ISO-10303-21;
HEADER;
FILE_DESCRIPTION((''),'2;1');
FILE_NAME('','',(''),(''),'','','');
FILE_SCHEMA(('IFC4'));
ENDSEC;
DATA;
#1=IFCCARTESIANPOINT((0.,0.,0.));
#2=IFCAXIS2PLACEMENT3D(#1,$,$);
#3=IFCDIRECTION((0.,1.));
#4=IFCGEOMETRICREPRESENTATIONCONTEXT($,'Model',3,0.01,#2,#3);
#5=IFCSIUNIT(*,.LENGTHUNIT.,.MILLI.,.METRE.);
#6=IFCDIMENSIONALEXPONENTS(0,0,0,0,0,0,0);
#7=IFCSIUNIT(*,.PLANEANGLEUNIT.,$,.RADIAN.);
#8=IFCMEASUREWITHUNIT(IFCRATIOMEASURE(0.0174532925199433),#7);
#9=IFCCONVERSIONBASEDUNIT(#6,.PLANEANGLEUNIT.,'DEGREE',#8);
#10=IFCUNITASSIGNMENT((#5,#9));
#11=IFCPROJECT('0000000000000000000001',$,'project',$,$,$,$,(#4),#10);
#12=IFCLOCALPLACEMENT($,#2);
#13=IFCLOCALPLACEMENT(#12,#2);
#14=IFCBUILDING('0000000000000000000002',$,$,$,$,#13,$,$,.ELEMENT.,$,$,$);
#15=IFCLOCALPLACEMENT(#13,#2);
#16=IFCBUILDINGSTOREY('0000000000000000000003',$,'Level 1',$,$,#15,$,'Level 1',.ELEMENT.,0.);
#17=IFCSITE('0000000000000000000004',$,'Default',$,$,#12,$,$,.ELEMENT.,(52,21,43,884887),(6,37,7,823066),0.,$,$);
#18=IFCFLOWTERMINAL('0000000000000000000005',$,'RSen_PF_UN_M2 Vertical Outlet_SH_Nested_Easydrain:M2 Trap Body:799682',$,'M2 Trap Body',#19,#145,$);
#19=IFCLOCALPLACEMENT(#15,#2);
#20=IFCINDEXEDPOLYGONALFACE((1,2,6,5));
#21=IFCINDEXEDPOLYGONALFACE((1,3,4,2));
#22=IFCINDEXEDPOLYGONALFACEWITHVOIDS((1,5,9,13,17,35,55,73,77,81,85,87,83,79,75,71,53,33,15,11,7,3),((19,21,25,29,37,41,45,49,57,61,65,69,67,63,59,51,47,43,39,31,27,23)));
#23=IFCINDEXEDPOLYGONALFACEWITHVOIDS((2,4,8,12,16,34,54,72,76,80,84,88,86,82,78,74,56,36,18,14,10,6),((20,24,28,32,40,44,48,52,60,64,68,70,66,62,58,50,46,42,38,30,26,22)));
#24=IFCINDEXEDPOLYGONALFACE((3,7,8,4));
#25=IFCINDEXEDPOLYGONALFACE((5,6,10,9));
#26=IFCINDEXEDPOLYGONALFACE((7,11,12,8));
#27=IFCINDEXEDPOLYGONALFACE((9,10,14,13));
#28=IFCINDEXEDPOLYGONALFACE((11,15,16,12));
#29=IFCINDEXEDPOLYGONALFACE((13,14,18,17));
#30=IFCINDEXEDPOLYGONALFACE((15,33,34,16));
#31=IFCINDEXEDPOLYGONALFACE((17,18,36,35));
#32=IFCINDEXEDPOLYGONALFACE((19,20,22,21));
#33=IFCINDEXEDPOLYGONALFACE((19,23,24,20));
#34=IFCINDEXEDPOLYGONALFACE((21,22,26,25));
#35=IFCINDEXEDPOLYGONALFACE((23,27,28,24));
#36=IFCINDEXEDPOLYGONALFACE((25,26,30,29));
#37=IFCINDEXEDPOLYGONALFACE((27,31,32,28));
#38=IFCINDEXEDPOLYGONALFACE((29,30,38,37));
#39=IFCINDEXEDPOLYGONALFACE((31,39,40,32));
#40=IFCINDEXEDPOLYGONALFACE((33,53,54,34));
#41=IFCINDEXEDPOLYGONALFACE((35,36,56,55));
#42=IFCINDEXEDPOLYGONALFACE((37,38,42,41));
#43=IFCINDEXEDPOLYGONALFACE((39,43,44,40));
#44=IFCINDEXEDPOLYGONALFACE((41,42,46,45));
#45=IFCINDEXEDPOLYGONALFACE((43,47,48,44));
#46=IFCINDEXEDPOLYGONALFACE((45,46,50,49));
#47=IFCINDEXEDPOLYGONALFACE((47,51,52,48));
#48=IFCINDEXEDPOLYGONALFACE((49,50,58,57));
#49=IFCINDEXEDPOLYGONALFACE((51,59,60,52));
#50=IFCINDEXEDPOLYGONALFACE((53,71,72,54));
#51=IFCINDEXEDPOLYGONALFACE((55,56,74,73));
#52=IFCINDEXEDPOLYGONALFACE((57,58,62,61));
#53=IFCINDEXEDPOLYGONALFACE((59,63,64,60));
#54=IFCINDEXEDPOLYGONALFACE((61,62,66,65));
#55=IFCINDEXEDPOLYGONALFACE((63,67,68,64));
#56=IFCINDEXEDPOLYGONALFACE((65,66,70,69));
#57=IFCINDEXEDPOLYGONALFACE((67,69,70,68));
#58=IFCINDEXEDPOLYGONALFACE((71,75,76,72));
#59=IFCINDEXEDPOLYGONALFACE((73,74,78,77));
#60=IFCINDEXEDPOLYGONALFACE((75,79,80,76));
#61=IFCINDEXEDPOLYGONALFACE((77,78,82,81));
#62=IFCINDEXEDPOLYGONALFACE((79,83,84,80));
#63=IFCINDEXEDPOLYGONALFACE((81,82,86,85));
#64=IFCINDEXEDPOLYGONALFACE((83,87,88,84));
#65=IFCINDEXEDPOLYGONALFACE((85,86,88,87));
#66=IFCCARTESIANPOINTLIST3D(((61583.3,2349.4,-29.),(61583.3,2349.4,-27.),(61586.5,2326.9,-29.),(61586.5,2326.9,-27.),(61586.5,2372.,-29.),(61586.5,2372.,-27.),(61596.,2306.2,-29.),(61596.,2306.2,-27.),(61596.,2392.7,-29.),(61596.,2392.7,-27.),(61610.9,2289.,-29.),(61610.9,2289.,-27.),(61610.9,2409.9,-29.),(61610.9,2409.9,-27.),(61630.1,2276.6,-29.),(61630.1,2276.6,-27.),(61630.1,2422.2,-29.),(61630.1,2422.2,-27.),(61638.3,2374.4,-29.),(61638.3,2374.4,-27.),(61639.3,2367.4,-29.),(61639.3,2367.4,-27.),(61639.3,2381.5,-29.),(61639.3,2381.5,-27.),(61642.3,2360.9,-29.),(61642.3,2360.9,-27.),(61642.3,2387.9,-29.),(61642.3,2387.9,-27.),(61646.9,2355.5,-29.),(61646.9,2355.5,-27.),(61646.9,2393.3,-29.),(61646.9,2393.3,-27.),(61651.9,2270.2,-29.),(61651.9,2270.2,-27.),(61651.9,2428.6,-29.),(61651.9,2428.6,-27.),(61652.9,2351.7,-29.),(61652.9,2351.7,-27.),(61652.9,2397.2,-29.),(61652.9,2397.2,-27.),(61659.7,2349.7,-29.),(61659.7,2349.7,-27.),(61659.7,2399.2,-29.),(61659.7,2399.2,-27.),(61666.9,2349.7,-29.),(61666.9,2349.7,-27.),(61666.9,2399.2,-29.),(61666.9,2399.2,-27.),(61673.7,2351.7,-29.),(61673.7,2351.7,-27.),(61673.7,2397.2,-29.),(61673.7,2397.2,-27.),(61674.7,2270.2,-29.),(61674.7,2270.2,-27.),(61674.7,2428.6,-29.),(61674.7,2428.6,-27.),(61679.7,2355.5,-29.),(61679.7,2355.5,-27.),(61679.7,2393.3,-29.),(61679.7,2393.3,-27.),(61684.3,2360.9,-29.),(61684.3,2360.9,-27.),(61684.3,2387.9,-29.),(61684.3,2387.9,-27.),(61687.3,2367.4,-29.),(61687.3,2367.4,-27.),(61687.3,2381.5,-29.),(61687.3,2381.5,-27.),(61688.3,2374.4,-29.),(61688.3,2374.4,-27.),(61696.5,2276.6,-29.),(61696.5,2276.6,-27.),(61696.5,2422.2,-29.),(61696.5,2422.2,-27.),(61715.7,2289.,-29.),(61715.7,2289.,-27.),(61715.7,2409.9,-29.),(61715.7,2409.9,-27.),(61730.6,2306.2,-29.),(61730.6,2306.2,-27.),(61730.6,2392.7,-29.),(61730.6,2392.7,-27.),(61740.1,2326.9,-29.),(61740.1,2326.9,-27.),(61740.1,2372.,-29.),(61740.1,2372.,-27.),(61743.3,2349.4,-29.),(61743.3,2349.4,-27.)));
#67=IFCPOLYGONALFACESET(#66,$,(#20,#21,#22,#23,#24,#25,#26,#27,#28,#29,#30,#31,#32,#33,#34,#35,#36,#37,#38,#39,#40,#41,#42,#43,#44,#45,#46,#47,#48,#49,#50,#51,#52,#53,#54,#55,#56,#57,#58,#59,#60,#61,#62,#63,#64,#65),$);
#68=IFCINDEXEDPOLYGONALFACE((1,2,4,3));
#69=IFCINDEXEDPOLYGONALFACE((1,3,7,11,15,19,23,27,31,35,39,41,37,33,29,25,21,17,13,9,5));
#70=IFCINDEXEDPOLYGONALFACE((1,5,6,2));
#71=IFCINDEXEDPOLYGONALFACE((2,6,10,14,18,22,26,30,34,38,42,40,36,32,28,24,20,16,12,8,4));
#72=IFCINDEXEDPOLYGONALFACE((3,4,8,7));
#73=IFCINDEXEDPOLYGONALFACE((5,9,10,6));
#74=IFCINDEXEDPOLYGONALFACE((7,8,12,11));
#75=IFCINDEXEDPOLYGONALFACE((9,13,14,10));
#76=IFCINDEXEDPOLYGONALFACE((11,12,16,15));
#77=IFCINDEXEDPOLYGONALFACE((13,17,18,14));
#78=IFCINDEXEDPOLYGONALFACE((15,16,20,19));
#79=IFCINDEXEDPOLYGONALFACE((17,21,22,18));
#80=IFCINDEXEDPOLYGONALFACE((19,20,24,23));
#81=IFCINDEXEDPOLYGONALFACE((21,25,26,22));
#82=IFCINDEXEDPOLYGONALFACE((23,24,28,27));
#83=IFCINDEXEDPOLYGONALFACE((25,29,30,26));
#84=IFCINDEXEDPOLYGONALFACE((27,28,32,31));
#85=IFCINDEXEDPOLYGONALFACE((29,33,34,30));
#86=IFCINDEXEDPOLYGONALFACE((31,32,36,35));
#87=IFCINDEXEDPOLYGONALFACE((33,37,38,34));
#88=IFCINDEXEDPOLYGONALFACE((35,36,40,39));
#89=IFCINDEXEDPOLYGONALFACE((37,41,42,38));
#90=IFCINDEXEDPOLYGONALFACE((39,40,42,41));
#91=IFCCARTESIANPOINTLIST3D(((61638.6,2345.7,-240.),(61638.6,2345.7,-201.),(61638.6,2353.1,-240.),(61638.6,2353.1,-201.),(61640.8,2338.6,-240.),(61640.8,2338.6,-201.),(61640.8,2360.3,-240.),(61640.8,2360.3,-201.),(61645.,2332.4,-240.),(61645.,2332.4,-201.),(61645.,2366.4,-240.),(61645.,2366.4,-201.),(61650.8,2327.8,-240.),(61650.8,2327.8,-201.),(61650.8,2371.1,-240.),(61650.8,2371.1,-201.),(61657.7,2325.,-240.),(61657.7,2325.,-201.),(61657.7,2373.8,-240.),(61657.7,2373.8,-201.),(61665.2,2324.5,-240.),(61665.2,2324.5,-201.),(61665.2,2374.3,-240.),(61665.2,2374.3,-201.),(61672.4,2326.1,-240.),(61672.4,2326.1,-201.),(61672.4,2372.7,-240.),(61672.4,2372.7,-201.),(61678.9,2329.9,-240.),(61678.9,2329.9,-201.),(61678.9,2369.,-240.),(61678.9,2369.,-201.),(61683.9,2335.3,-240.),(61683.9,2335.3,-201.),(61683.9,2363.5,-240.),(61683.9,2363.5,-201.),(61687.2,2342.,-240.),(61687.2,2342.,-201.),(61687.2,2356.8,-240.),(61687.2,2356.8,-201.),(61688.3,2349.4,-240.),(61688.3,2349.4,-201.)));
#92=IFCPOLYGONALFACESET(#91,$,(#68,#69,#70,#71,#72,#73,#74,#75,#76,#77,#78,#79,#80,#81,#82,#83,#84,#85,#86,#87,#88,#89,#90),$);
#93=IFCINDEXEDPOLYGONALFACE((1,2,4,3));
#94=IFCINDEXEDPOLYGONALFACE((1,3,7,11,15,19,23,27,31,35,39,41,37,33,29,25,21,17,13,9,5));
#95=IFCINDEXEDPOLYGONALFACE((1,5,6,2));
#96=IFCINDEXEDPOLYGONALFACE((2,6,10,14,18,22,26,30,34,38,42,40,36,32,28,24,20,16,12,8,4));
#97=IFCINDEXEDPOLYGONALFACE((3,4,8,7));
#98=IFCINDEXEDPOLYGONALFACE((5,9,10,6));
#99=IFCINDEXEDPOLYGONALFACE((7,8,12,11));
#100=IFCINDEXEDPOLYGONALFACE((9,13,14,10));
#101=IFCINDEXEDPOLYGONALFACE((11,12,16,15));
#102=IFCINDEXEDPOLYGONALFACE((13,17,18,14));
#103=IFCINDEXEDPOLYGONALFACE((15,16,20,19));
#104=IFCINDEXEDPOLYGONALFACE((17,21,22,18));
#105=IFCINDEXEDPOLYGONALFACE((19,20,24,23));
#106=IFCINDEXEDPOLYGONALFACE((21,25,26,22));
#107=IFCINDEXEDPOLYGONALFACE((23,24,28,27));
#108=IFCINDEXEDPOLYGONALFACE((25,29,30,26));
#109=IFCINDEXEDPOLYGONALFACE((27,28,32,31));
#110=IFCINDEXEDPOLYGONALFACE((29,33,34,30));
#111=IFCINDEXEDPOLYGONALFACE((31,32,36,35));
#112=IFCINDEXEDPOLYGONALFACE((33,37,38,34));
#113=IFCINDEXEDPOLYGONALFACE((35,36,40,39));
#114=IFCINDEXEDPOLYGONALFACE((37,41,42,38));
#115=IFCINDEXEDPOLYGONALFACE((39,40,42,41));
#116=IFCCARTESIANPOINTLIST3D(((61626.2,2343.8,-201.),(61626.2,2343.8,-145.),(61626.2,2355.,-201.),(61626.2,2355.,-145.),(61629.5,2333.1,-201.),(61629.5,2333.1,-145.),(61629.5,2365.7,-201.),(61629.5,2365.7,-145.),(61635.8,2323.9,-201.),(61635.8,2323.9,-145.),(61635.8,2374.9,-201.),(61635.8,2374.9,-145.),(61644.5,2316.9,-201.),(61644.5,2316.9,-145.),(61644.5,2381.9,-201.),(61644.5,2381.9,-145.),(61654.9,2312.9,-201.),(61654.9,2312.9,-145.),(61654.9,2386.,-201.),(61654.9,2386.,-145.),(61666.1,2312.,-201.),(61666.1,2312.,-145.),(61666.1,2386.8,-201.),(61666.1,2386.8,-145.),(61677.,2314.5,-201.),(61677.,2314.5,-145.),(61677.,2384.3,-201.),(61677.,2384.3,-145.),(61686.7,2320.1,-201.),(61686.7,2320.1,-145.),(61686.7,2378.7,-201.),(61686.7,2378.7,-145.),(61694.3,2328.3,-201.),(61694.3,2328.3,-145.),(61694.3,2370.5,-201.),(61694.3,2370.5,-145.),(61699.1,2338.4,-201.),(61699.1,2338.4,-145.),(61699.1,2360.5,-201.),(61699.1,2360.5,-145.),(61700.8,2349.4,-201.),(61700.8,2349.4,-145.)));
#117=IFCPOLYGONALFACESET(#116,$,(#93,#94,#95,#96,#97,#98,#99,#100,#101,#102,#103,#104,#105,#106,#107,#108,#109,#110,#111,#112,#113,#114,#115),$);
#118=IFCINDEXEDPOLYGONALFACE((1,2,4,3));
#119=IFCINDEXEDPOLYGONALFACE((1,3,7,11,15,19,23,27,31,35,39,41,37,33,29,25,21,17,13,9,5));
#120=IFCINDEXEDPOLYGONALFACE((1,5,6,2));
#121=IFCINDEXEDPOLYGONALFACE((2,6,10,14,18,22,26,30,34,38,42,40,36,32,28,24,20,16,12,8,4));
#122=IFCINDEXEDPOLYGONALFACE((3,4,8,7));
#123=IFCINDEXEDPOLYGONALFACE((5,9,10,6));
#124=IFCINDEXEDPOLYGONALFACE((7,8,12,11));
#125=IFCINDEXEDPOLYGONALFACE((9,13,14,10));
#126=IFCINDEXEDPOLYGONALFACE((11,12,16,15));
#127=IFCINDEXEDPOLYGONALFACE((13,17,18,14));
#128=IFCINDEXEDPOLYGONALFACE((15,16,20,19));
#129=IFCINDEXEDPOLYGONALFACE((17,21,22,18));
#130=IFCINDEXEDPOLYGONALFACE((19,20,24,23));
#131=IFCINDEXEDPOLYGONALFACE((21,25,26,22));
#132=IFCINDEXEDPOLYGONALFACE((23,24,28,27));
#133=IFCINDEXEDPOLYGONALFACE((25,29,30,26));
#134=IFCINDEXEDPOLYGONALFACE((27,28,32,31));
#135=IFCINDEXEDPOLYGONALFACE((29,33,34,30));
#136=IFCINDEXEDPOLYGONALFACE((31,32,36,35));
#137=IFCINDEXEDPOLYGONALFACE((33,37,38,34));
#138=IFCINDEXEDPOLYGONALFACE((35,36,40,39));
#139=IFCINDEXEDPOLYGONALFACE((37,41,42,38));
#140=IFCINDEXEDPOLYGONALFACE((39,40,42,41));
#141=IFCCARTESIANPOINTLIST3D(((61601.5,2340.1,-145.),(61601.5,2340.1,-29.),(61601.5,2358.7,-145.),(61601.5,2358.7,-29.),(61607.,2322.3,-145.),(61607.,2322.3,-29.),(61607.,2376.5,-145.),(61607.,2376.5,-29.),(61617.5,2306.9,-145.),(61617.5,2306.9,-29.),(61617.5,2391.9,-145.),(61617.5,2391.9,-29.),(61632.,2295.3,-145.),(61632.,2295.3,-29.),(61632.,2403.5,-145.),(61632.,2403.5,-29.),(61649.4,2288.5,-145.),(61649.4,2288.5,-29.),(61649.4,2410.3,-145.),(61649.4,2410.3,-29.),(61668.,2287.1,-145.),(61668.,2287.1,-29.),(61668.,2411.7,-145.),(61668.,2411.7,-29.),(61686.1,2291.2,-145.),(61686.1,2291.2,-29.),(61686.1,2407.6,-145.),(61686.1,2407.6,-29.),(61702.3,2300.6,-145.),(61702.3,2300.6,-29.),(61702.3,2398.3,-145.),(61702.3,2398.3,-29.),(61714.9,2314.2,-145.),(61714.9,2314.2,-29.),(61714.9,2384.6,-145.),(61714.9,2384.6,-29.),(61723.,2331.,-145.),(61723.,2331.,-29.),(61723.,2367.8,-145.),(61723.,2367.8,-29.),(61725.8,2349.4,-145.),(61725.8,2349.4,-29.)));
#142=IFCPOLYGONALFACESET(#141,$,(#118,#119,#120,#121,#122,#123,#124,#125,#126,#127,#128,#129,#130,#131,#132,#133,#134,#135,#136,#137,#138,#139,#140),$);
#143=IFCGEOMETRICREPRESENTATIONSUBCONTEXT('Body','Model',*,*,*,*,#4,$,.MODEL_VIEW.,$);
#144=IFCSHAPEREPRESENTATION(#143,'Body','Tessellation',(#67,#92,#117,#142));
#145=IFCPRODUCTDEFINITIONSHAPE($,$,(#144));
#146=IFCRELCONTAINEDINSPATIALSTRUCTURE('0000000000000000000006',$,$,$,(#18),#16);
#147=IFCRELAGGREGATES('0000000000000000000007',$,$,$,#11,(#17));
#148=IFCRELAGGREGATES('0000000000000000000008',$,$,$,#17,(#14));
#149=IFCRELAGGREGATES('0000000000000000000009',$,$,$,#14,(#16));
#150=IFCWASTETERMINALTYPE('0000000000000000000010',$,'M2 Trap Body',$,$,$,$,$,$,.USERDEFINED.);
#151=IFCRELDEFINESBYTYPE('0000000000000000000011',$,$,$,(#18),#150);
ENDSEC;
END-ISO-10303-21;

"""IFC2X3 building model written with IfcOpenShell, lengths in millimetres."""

from ifc_helpers import new_model, entity, si_unit, converted_unit, direction, frame, frame_2d, origin, origin_2d_with_axis, place, context, subcontext, project, spatial, circle_curve, parameter, trimmed, segment, composite_curve, circle, outline, extrude, source, transform, mapped, type_object, type_shapes, element, save


model = new_model("IFC2X3")

# Units and contexts
model_context = context("Model", 3, precision=0.01, world=origin(), true_north=direction((0.0, 1.0)))
body_context = subcontext(model_context, "Body", "Model", "MODEL_VIEW")
ifc_project = project(units=[si_unit("LENGTHUNIT", "METRE", prefix="MILLI"), converted_unit("PLANEANGLEUNIT", "DEGREE", entity("IfcRatioMeasure", 0.0174532925199433), si_unit("PLANEANGLEUNIT", "RADIAN"), dimensions=[0, 0, 0, 0, 0, 0, 0])], contexts=[model_context])

# Site, building, storey
site_placement = place(None, origin())
site = spatial("IfcSite", under=ifc_project, at=site_placement, Name="Default", CompositionType="ELEMENT", RefLatitude=(52, 21, 43, 884887), RefLongitude=(6, 37, 7, 823066), RefElevation=0.0)
building_placement = place(site_placement, origin())
building = spatial("IfcBuilding", under=site, at=building_placement, CompositionType="ELEMENT")
storey_placement = place(building_placement, origin())
storey = spatial("IfcBuildingStorey", under=building, at=storey_placement, Name="Level 1", LongName="Level 1", CompositionType="ELEMENT", Elevation=0.0)

# Flow terminal
waste_terminal_type_1 = type_object("IfcWasteTerminalType", Name="M2 Trap Body", PredefinedType="USERDEFINED")
shared_shape_1 = source(origin(), body_context, "Body", "SweptSolid", [
    extrude(outline(composite_curve([segment(trimmed(circle_curve(origin_2d_with_axis(), 80.0), [parameter(0.0)], [parameter(180.0)], True, "PARAMETER"), True, "CONTINUOUS"), segment(trimmed(circle_curve(origin_2d_with_axis(), 80.0), [parameter(180.0)], [parameter(360.0)], True, "PARAMETER"), True, "CONTINUOUS")], self_intersect=False), holes=[composite_curve([segment(trimmed(circle_curve(frame_2d((0.0, 25.0), x_axis=(1.0, 0.0)), 25.0), [parameter(180.0)], [parameter(360.0)], True, "PARAMETER"), False, "CONTINUOUS"), segment(trimmed(circle_curve(frame_2d((0.0, 25.0), x_axis=(1.0, 0.0)), 25.0), [parameter(0.0)], [parameter(180.0)], True, "PARAMETER"), False, "CONTINUOUS")], self_intersect=False)]), frame((0.0, -25.0, -2.0)), (0.0, 0.0, 1.0), 2.0),
    extrude(circle(Radius=25.0, at=frame_2d((0.0, 0.0), x_axis=(1.0, 0.0))), frame((0.0, -25.0, -213.0)), (0.0, 0.0, 1.0), 39.0),
    extrude(circle(Radius=37.5, at=frame_2d((0.0, 0.0), x_axis=(1.0, 0.0))), frame((0.0, -25.0, -174.0)), (0.0, 0.0, 1.0), 56.0),
    extrude(circle(Radius=62.5, at=frame_2d((0.0, 0.0), x_axis=(1.0, 0.0))), frame((0.0, -25.0, -118.0)), (0.0, 0.0, 1.0), 116.0),
])
type_shapes(waste_terminal_type_1, [shared_shape_1])
for number, where, name in (
    (1, (61663.3, 2374.4, -27.0), "RSen_PF_UN_M2 Vertical Outlet_SH_Nested_Easydrain:M2 Trap Body:799682"),
):
    element("IfcFlowTerminal", number, at=place(storey_placement, frame(where)), inside=storey, type_object=waste_terminal_type_1, Name=name, ObjectType="M2 Trap Body", context=body_context, shape_type="MappedRepresentation", body=[
        mapped(shared_shape_1, transform((0.0, 0.0, 0.0), scale=1.0)),
    ])

save(model, "model.ifc")
